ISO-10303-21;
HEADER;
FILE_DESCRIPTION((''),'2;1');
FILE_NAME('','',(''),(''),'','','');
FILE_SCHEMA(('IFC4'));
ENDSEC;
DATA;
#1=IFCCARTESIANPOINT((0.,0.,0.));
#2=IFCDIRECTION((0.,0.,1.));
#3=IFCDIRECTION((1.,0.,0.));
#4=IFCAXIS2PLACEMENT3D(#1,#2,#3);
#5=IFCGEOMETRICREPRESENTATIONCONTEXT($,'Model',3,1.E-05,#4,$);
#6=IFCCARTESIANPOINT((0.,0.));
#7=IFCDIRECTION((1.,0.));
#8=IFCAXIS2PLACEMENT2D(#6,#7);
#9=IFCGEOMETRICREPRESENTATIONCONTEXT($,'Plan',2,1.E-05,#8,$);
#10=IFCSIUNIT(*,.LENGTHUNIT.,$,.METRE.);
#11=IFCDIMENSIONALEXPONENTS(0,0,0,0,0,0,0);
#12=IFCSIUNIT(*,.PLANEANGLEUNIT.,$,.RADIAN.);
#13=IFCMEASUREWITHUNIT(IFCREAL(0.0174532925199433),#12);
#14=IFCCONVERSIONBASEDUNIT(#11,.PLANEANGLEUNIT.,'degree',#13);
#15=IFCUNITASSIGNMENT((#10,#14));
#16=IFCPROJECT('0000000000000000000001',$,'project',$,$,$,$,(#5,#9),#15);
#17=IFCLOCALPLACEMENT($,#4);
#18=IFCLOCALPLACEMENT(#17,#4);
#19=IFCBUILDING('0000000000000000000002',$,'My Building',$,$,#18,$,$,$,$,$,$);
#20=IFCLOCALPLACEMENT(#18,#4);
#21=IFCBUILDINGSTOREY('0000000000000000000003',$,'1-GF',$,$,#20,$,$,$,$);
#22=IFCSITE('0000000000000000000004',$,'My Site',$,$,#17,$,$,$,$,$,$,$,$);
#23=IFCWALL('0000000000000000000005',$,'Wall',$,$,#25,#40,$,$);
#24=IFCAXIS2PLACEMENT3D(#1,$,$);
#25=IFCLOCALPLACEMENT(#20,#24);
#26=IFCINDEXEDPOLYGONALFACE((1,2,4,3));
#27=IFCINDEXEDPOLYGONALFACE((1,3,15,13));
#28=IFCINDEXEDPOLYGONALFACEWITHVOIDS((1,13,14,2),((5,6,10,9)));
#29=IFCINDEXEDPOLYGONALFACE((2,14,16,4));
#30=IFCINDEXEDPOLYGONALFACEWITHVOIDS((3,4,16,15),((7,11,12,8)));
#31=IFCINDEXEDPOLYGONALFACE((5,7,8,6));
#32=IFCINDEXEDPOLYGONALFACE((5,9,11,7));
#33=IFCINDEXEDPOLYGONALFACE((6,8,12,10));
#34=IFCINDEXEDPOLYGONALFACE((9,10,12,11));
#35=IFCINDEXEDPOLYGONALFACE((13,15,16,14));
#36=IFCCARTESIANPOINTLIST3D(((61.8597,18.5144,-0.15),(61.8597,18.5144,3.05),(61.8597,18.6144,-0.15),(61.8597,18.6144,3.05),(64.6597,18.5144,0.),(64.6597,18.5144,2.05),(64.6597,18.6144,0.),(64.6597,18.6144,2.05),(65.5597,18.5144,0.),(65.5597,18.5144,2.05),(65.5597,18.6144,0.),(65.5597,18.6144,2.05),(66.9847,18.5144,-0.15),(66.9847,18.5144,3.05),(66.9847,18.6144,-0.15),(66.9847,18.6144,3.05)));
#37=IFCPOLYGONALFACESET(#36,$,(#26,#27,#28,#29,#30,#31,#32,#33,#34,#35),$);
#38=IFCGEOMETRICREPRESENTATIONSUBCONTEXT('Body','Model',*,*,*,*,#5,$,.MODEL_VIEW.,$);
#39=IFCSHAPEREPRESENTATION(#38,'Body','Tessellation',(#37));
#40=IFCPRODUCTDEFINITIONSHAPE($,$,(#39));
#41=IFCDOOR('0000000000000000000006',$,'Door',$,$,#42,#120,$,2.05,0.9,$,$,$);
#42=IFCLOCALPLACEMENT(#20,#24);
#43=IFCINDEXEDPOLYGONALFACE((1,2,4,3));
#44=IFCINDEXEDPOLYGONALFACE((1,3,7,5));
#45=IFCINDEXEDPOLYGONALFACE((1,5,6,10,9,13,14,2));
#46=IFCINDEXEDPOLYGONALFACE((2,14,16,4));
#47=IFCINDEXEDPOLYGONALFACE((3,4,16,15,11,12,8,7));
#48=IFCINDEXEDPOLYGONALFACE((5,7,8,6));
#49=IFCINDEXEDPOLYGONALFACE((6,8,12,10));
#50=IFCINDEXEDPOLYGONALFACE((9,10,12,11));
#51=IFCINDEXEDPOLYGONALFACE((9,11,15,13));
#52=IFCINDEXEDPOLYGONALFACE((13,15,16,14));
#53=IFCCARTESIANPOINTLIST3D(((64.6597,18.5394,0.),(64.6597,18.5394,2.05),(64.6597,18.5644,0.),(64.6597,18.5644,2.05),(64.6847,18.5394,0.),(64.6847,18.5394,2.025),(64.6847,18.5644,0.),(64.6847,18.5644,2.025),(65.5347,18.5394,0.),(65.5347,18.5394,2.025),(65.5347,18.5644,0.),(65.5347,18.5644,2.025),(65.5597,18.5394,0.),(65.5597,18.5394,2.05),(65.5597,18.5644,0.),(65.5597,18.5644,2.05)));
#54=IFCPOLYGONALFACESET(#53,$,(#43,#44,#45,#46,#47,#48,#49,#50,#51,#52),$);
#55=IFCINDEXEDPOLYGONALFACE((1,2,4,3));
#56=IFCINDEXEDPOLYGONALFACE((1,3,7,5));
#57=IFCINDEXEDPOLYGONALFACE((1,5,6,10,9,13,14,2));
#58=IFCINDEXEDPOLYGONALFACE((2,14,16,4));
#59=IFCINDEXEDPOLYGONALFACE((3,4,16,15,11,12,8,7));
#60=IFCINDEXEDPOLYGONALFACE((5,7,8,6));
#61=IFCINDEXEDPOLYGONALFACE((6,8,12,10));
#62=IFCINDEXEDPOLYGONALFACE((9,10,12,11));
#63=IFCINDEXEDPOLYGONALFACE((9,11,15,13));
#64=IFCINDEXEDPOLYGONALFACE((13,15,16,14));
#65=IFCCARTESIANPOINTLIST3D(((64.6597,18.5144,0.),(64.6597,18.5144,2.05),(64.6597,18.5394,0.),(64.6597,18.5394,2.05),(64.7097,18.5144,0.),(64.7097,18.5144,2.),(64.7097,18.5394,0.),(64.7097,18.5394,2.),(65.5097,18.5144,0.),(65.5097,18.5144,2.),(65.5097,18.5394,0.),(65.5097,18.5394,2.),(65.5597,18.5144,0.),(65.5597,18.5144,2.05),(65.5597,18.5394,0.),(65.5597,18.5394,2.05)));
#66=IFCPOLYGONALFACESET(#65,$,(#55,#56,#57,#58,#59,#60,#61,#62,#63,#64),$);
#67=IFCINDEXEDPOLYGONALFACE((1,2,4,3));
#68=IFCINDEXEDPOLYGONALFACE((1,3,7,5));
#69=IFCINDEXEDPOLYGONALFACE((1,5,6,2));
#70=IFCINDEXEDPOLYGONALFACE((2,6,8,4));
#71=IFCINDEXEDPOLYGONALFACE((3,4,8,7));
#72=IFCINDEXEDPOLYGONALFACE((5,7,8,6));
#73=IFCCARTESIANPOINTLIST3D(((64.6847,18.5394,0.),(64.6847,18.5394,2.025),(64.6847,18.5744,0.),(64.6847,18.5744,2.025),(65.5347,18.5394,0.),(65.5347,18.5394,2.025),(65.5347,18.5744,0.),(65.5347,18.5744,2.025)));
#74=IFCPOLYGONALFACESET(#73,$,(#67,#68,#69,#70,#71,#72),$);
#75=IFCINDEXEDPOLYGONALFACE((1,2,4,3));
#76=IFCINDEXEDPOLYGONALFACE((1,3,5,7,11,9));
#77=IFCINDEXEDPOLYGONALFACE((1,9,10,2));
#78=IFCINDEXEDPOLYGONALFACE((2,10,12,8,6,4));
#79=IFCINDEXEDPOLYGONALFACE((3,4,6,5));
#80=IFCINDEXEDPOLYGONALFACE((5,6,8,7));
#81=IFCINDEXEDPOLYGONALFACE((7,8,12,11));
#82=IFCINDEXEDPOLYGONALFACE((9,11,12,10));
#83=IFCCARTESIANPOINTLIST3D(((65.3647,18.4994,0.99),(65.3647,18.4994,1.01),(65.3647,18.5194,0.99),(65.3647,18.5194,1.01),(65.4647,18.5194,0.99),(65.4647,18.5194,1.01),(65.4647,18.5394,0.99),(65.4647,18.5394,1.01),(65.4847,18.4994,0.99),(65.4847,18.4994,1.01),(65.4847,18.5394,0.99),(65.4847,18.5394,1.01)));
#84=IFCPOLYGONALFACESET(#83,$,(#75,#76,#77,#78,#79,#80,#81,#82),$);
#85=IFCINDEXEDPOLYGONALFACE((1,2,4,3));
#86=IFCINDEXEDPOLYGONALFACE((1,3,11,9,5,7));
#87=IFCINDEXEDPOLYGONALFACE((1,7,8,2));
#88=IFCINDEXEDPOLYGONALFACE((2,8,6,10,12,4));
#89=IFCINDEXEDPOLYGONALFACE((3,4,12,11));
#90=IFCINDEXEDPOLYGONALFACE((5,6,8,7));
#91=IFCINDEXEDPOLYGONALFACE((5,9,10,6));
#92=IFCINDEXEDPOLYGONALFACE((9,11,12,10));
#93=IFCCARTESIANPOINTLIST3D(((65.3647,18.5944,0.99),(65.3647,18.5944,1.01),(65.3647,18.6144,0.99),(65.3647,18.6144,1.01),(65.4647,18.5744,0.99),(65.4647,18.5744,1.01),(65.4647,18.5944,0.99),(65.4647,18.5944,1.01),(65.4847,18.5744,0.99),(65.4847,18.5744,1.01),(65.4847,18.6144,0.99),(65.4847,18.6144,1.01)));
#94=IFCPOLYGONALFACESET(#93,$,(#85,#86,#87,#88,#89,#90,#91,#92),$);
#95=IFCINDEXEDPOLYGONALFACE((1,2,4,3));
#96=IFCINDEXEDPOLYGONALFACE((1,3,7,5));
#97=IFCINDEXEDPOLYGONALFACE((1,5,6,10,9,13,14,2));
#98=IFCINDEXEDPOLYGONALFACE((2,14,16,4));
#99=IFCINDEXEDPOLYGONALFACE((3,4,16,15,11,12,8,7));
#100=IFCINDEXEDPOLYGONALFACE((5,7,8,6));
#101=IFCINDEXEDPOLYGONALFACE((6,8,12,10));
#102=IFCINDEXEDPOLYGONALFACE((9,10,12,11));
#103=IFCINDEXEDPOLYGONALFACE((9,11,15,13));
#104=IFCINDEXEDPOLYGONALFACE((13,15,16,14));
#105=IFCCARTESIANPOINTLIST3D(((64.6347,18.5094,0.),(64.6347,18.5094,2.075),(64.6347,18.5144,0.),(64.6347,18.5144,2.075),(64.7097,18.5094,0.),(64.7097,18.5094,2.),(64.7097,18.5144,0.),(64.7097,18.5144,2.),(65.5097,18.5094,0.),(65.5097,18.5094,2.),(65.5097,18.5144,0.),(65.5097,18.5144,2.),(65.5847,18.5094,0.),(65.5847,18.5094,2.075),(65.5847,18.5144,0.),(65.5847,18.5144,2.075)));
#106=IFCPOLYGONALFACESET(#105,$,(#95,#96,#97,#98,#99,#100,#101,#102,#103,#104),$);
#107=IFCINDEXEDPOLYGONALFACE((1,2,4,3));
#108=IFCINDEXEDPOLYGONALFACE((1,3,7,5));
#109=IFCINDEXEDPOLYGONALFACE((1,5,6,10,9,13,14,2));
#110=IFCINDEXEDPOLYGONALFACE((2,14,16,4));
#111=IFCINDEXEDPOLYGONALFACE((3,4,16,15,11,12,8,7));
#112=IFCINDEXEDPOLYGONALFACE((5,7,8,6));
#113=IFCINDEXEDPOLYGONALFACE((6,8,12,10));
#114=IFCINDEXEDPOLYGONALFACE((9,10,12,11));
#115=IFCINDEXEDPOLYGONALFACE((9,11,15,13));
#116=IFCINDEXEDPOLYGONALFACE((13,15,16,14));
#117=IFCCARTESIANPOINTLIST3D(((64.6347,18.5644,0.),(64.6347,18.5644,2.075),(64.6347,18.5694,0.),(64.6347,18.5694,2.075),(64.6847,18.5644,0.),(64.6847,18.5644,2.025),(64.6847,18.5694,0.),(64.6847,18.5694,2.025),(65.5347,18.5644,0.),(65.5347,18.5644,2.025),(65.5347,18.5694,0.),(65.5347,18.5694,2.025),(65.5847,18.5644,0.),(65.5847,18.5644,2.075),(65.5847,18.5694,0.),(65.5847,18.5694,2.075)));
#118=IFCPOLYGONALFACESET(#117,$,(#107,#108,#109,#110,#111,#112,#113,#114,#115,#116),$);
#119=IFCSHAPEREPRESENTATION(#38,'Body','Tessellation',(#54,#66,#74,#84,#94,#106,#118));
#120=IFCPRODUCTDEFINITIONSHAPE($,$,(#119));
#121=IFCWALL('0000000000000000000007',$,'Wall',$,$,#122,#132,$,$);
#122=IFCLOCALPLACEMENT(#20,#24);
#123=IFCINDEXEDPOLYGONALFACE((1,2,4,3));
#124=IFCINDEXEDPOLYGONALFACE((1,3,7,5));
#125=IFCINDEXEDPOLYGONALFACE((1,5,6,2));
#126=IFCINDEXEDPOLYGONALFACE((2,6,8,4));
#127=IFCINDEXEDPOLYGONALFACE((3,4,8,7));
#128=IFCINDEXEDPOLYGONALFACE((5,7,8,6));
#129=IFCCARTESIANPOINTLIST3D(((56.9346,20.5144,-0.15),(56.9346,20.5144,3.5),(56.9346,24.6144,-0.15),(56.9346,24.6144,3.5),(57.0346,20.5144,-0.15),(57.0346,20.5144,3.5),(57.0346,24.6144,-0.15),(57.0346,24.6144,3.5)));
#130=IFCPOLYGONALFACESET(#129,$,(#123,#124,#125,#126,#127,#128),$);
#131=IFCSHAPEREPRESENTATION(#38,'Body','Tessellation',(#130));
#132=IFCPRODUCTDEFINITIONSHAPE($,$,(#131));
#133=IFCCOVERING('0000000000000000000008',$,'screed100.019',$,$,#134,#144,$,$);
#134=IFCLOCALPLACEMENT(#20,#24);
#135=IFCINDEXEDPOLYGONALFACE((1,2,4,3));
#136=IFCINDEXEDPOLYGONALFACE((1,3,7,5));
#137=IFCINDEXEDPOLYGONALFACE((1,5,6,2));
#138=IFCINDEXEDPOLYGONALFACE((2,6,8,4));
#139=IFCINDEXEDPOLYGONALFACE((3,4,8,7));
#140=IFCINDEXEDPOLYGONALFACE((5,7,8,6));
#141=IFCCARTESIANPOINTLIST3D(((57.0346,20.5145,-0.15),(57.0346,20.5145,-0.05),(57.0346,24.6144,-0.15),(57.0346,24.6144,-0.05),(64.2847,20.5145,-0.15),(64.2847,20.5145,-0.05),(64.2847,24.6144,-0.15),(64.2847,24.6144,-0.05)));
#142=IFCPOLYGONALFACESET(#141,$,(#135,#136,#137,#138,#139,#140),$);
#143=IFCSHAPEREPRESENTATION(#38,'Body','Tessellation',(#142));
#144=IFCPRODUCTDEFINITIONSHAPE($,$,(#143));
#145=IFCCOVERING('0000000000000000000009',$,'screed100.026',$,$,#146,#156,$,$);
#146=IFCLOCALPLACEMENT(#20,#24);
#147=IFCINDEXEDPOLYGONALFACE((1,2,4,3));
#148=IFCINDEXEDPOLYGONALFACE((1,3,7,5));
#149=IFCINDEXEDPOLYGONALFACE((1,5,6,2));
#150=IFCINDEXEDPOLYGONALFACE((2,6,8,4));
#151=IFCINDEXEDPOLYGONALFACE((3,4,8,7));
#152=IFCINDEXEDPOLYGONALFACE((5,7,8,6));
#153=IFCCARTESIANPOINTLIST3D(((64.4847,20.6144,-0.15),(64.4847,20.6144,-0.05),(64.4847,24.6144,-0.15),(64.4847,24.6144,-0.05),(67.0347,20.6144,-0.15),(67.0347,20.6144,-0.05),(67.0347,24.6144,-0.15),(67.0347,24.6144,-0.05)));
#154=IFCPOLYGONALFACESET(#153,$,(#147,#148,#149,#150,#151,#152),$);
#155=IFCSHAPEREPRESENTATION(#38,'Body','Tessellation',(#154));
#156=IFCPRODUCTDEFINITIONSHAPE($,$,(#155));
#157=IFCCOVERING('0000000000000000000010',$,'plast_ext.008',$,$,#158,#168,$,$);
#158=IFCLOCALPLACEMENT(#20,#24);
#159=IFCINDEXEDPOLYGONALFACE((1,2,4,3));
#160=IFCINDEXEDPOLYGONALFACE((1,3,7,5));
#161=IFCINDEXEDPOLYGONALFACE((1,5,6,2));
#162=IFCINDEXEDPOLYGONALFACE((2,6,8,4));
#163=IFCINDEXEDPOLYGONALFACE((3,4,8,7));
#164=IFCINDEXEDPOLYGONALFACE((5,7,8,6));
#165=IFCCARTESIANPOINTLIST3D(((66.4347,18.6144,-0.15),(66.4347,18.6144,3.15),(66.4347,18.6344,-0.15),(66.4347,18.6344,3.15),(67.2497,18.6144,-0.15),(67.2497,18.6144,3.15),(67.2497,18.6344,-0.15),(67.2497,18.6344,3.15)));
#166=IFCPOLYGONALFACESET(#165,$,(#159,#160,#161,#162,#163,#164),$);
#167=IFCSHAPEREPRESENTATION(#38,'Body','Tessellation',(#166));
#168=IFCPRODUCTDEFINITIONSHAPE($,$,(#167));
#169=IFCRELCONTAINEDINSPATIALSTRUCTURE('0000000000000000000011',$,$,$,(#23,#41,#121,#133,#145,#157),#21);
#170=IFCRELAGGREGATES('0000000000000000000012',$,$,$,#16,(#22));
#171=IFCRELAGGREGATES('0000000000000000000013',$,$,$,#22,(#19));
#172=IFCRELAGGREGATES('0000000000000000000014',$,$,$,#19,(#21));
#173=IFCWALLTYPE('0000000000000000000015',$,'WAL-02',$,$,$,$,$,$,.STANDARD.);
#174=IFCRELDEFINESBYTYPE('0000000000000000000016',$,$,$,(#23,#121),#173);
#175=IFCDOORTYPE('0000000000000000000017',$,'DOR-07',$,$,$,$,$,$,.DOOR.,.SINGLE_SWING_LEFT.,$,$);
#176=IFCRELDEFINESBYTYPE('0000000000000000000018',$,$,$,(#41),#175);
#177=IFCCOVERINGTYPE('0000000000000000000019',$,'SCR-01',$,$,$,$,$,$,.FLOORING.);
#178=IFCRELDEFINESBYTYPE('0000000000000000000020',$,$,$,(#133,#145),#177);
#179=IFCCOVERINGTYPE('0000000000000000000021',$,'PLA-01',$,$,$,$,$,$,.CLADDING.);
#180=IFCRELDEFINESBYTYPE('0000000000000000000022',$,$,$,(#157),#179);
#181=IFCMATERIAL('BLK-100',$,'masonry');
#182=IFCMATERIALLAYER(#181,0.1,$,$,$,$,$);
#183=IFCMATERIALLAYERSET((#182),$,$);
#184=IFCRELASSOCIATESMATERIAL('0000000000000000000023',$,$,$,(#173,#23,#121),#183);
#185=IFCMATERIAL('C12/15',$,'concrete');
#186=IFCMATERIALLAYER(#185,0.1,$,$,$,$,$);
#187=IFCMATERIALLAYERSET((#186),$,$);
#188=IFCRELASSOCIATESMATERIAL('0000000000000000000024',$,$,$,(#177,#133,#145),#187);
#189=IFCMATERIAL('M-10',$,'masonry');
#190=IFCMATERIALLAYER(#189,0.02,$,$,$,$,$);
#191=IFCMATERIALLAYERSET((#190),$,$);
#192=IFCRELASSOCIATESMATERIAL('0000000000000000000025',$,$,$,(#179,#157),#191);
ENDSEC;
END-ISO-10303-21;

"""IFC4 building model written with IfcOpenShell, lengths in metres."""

from ifc_helpers import new_model, entity, si_unit, converted_unit, frame, origin_with_axes, origin_2d_with_axis, place, context, subcontext, project, spatial, line, indexed_curve, outline, extrude, shape, source, transform, mapped, material, layer, layer_set, layer_usage, type_object, type_shapes, element, fill, save


model = new_model("IFC4")

# Units and contexts
model_context = context("Model", 3, precision=1e-05, world=origin_with_axes())
plan_context = context("Plan", 2, precision=1e-05, world=origin_2d_with_axis())
body_context_1 = subcontext(model_context, "Body", "Model", "MODEL_VIEW")
body_context_2 = subcontext(plan_context, "Body", "Plan", "PLAN_VIEW")
ifc_project = project(units=[si_unit("LENGTHUNIT", "METRE"), converted_unit("PLANEANGLEUNIT", "degree", entity("IfcReal", 0.0174532925199433), si_unit("PLANEANGLEUNIT", "RADIAN"), dimensions=[0, 0, 0, 0, 0, 0, 0])], contexts=[model_context, plan_context])

# Site, building, storey
site_placement = place(None, origin_with_axes())
site = spatial("IfcSite", under=ifc_project, at=site_placement, Name="My Site")
building_placement = place(site_placement, origin_with_axes())
building = spatial("IfcBuilding", under=site, at=building_placement, Name="My Building")
storey_placement = place(building_placement, origin_with_axes())
storey = spatial("IfcBuildingStorey", under=building, at=storey_placement, Name="1-GF")

# Shared definitions
ifc_material_1 = material(Name="BLK-100", Category="masonry")
ifc_layer_1 = layer(ifc_material_1, 0.1)
ifc_layer_set_1 = layer_set([ifc_layer_1])
wall_type_1 = type_object("IfcWallType", Name="WAL-02", PredefinedType="STANDARD", material=ifc_layer_set_1)

# Wall, opening, door
ifc_layer_usage_1 = layer_usage(ifc_layer_set_1, "AXIS2", "POSITIVE", 0.0)
wall_1_placement = place(storey_placement, frame((61.8597, 18.5144, -0.15), z_axis=(0.0, 0.0, 1.0), x_axis=(1.0, -0.000001, 0.0)))
wall_1 = element("IfcWall", 1, at=wall_1_placement, inside=storey, type_object=wall_type_1, material=ifc_layer_usage_1, Name="Wall", context=body_context_1, shape_type="SweptSolid", body=[
    extrude(outline(indexed_curve([(0.0, 0.0), (0.0, 0.1), (5.125, 0.1), (5.125, 0.0), (0.0, 0.0)], self_intersect=False)), origin_with_axes(), (0.0, 0.0, 1.0), 3.2),
])
shared_shape_1 = source(origin_with_axes(), body_context_1, "Body", "SweptSolid", [
    extrude(outline(indexed_curve([(0.0, 0.0), (0.9, 0.0), (0.9, 2.05), (0.0, 2.05)], segments=[line(1, 2, 3, 4, 1)])), frame((0.0, -0.6, 0.0), z_axis=(0.0, -1.0, 0.0), x_axis=(1.0, 0.0, 0.0)), (0.0, 0.0, -1.0), 1.2),
])
opening_1_placement = place(wall_1_placement, frame((2.8, 0.0, 0.15), z_axis=(0.0, 0.0, 1.0), x_axis=(1.0, 0.0, 0.0)))
opening_1 = element("IfcOpeningElement", 2, at=opening_1_placement, cuts=wall_1, PredefinedType="OPENING", context=body_context_1, shape_type="MappedRepresentation", body=[
    mapped(shared_shape_1, transform((0.0, 0.0, 0.0), x_axis=(1.0, 0.0, 0.0), y_axis=(0.0, 1.0, 0.0), z_axis=(0.0, 0.0, 1.0), scale=1.0)),
])
door_type_1 = type_object("IfcDoorType", Name="DOR-07", OperationType="SINGLE_SWING_LEFT", PredefinedType="DOOR")
shared_shape_2 = source(origin_with_axes(), body_context_1, "Body", "SweptSolid", [
    extrude(outline(indexed_curve([(0.0, 0.0), (0.0, 2.05), (0.9, 2.05), (0.9, 0.0), (0.875, 0.0), (0.875, 2.025), (0.025, 2.025), (0.025, 0.0)], segments=[line(1, 2, 3, 4, 5, 6, 7, 8, 1)])), frame((0.0, 0.025, 0.0), z_axis=(0.0, -1.0, 0.0), x_axis=(1.0, 0.0, 0.0)), (0.0, 0.0, -1.0), 0.025),
    extrude(outline(indexed_curve([(0.0, 0.0), (0.0, 2.05), (0.9, 2.05), (0.9, 0.0), (0.85, 0.0), (0.85, 2.0), (0.05, 2.0), (0.05, 0.0)], segments=[line(1, 2, 3, 4, 5, 6, 7, 8, 1)])), frame((0.0, 0.0, 0.0), z_axis=(0.0, -1.0, 0.0), x_axis=(1.0, 0.0, 0.0)), (0.0, 0.0, -1.0), 0.025),
    extrude(outline(indexed_curve([(0.0, 0.0), (0.85, 0.0), (0.85, 0.035), (0.0, 0.035)], segments=[line(1, 2, 3, 4, 1)])), frame((0.025, 0.025, 0.0), z_axis=(0.0, 0.0, 1.0), x_axis=(1.0, 0.0, 0.0)), (0.0, 0.0, 1.0), 2.025),
    extrude(outline(indexed_curve([(0.0, 0.0), (0.0, -0.04), (-0.12, -0.04), (-0.12, -0.02), (-0.02, -0.02), (-0.02, 0.0)], segments=[line(1, 2, 3, 4, 5, 6, 1)])), frame((0.825, 0.025, 0.99), z_axis=(0.0, 0.0, 1.0), x_axis=(1.0, 0.0, 0.0)), (0.0, 0.0, 1.0), 0.02),
    extrude(outline(indexed_curve([(0.0, 0.0), (0.0, 0.04), (-0.12, 0.04), (-0.12, 0.02), (-0.02, 0.02), (-0.02, 0.0)], segments=[line(1, 2, 3, 4, 5, 6, 1)])), frame((0.825, 0.06, 0.99), z_axis=(0.0, 0.0, 1.0), x_axis=(1.0, 0.0, 0.0)), (0.0, 0.0, 1.0), 0.02),
    extrude(outline(indexed_curve([(0.0, 0.0), (0.0, 2.075), (0.95, 2.075), (0.95, 0.0), (0.875, 0.0), (0.875, 2.0), (0.075, 2.0), (0.075, 0.0)], segments=[line(1, 2, 3, 4, 5, 6, 7, 8, 1)])), frame((-0.025, -0.005, 0.0), z_axis=(0.0, -1.0, 0.0), x_axis=(1.0, 0.0, 0.0)), (0.0, 0.0, -1.0), 0.005),
    extrude(outline(indexed_curve([(0.0, 0.0), (0.0, 2.075), (0.95, 2.075), (0.95, 0.0), (0.9, 0.0), (0.9, 2.025), (0.05, 2.025), (0.05, 0.0)], segments=[line(1, 2, 3, 4, 5, 6, 7, 8, 1)])), frame((-0.025, 0.05, 0.0), z_axis=(0.0, -1.0, 0.0), x_axis=(1.0, 0.0, 0.0)), (0.0, 0.0, -1.0), 0.005),
])
shared_shape_3 = source(origin_with_axes(), body_context_2, "Body", "Curve2D", [
    entity("IfcIndexedPolyCurve", entity("IfcCartesianPointList2D", [[0.0, 0.0], [0.0, 0.05], [0.025, 0.05], [0.025, 0.025], [0.05, 0.025], [0.05, 0.0]]), [entity("IfcLineIndex", [1, 2, 3, 4, 5, 6, 1])]),
    entity("IfcIndexedPolyCurve", entity("IfcCartesianPointList2D", [[0.9, 0.0], [0.9, 0.05], [0.875, 0.05], [0.875, 0.025], [0.85, 0.025], [0.85, 0.0]]), [entity("IfcLineIndex", [1, 2, 3, 4, 5, 6, 1])]),
    entity("IfcTrimmedCurve", entity("IfcEllipse", entity("IfcAxis2Placement2D", entity("IfcCartesianPoint", [0.06, 0.05]), entity("IfcDirection", [1.0, 0.0])), 0.815, 0.85), [entity("IfcCartesianPoint", [0.875, 0.05])], [entity("IfcCartesianPoint", [0.06, 0.9])], True, "CARTESIAN"),
    entity("IfcIndexedPolyCurve", entity("IfcCartesianPointList2D", [[0.025, 0.05], [0.06, 0.05], [0.06, 0.9], [0.025, 0.9]]), [entity("IfcLineIndex", [1, 2, 3, 4, 1])]),
])
type_shapes(door_type_1, [shared_shape_2, shared_shape_3])
door_1_placement = place(opening_1_placement, frame((0.0, 0.0, 0.0), z_axis=(0.0, 0.0, 1.0), x_axis=(1.0, 0.0, 0.0)))
door_1 = element("IfcDoor", 3, at=door_1_placement, inside=storey, type_object=door_type_1, Name="Door", OverallHeight=2.05, OverallWidth=0.9, shapes=[
    shape(body_context_1, "Body", "MappedRepresentation", [mapped(shared_shape_2, transform((0.0, 0.0, 0.0), x_axis=(1.0, 0.0, 0.0), y_axis=(0.0, 1.0, 0.0), z_axis=(0.0, 0.0, 1.0), scale=1.0))]),
    shape(body_context_2, "Body", "MappedRepresentation", [mapped(shared_shape_3, transform((0.0, 0.0, 0.0), x_axis=(1.0, 0.0, 0.0), y_axis=(0.0, 1.0, 0.0), z_axis=(0.0, 0.0, 1.0), scale=1.0))]),
])
fill(opening_1, door_1)

# Wall
ifc_layer_usage_2 = layer_usage(ifc_layer_set_1, "AXIS2", "POSITIVE", 0.0)
wall_2_placement = place(storey_placement, frame((57.0346, 20.5144, -0.15), z_axis=(0.0, 0.0, 1.0), x_axis=(0.0, 1.0, 0.0)))
element("IfcWall", 4, at=wall_2_placement, inside=storey, type_object=wall_type_1, material=ifc_layer_usage_2, Name="Wall", context=body_context_1, shape_type="SweptSolid", body=[
    extrude(outline(indexed_curve([(0.0, 0.0), (0.0, 0.1), (4.1, 0.1), (4.1, 0.0), (0.0, 0.0)], self_intersect=False)), origin_with_axes(), (0.0, 0.0, 1.0), 3.65),
])

# Coverings
ifc_material_2 = material(Name="C12/15", Category="concrete")
ifc_layer_2 = layer(ifc_material_2, 0.1)
ifc_layer_set_2 = layer_set([ifc_layer_2])
ifc_layer_usage_3 = layer_usage(ifc_layer_set_2, "AXIS3", "POSITIVE", 0.0)
covering_type_1 = type_object("IfcCoveringType", Name="SCR-01", PredefinedType="FLOORING", material=ifc_layer_set_2)
covering_1_placement = place(storey_placement, frame((57.0346, 20.5145, -0.15), z_axis=(0.0, 0.0, 1.0), x_axis=(1.0, 0.0, 0.0)))
element("IfcCovering", 5, at=covering_1_placement, inside=storey, type_object=covering_type_1, material=ifc_layer_usage_3, Name="screed100.019", context=body_context_1, shape_type="SweptSolid", body=[
    extrude(outline(indexed_curve([(0.0, 0.0), (7.2501, 0.0), (7.2501, 4.0999), (0.0, 4.0999)], segments=[line(3, 2), line(2, 1), line(1, 4), line(4, 3)], self_intersect=False)), None, (0.0, 0.0, 1.0), 0.1),
])
ifc_layer_usage_4 = layer_usage(ifc_layer_set_2, "AXIS3", "POSITIVE", 0.0)
covering_2_placement = place(storey_placement, frame((64.4847, 24.6144, -0.15), z_axis=(0.0, 0.0, 1.0), x_axis=(1.0, 0.0, 0.0)))
element("IfcCovering", 6, at=covering_2_placement, inside=storey, type_object=covering_type_1, material=ifc_layer_usage_4, Name="screed100.026", context=body_context_1, shape_type="SweptSolid", body=[
    extrude(outline(indexed_curve([(0.0, -4.0), (2.55, -4.0), (2.55, 0.0), (0.0, 0.0)], segments=[line(3, 2), line(2, 1), line(1, 4), line(4, 3)], self_intersect=False)), None, (0.0, 0.0, 1.0), 0.1),
])
ifc_material_3 = material(Name="M-10", Category="masonry")
ifc_layer_3 = layer(ifc_material_3, 0.02)
ifc_layer_set_3 = layer_set([ifc_layer_3])
ifc_layer_usage_5 = layer_usage(ifc_layer_set_3, "AXIS2", "POSITIVE", 0.0)
covering_type_2 = type_object("IfcCoveringType", Name="PLA-01", PredefinedType="CLADDING", material=ifc_layer_set_3)
covering_3_placement = place(storey_placement, frame((67.2497, 18.6344, -0.15), z_axis=(0.0, 0.0, 1.0), x_axis=(-1.0, 0.0, 0.0)))
element("IfcCovering", 7, at=covering_3_placement, inside=storey, type_object=covering_type_2, material=ifc_layer_usage_5, Name="plast_ext.008", context=body_context_1, shape_type="SweptSolid", body=[
    extrude(outline(indexed_curve([(0.0, 0.0), (0.0, 0.02), (0.815, 0.02), (0.815, 0.0), (0.0, 0.0)], self_intersect=False)), origin_with_axes(), (0.0, 0.0, 1.0), 3.3),
])

save(model, "model.ifc")
